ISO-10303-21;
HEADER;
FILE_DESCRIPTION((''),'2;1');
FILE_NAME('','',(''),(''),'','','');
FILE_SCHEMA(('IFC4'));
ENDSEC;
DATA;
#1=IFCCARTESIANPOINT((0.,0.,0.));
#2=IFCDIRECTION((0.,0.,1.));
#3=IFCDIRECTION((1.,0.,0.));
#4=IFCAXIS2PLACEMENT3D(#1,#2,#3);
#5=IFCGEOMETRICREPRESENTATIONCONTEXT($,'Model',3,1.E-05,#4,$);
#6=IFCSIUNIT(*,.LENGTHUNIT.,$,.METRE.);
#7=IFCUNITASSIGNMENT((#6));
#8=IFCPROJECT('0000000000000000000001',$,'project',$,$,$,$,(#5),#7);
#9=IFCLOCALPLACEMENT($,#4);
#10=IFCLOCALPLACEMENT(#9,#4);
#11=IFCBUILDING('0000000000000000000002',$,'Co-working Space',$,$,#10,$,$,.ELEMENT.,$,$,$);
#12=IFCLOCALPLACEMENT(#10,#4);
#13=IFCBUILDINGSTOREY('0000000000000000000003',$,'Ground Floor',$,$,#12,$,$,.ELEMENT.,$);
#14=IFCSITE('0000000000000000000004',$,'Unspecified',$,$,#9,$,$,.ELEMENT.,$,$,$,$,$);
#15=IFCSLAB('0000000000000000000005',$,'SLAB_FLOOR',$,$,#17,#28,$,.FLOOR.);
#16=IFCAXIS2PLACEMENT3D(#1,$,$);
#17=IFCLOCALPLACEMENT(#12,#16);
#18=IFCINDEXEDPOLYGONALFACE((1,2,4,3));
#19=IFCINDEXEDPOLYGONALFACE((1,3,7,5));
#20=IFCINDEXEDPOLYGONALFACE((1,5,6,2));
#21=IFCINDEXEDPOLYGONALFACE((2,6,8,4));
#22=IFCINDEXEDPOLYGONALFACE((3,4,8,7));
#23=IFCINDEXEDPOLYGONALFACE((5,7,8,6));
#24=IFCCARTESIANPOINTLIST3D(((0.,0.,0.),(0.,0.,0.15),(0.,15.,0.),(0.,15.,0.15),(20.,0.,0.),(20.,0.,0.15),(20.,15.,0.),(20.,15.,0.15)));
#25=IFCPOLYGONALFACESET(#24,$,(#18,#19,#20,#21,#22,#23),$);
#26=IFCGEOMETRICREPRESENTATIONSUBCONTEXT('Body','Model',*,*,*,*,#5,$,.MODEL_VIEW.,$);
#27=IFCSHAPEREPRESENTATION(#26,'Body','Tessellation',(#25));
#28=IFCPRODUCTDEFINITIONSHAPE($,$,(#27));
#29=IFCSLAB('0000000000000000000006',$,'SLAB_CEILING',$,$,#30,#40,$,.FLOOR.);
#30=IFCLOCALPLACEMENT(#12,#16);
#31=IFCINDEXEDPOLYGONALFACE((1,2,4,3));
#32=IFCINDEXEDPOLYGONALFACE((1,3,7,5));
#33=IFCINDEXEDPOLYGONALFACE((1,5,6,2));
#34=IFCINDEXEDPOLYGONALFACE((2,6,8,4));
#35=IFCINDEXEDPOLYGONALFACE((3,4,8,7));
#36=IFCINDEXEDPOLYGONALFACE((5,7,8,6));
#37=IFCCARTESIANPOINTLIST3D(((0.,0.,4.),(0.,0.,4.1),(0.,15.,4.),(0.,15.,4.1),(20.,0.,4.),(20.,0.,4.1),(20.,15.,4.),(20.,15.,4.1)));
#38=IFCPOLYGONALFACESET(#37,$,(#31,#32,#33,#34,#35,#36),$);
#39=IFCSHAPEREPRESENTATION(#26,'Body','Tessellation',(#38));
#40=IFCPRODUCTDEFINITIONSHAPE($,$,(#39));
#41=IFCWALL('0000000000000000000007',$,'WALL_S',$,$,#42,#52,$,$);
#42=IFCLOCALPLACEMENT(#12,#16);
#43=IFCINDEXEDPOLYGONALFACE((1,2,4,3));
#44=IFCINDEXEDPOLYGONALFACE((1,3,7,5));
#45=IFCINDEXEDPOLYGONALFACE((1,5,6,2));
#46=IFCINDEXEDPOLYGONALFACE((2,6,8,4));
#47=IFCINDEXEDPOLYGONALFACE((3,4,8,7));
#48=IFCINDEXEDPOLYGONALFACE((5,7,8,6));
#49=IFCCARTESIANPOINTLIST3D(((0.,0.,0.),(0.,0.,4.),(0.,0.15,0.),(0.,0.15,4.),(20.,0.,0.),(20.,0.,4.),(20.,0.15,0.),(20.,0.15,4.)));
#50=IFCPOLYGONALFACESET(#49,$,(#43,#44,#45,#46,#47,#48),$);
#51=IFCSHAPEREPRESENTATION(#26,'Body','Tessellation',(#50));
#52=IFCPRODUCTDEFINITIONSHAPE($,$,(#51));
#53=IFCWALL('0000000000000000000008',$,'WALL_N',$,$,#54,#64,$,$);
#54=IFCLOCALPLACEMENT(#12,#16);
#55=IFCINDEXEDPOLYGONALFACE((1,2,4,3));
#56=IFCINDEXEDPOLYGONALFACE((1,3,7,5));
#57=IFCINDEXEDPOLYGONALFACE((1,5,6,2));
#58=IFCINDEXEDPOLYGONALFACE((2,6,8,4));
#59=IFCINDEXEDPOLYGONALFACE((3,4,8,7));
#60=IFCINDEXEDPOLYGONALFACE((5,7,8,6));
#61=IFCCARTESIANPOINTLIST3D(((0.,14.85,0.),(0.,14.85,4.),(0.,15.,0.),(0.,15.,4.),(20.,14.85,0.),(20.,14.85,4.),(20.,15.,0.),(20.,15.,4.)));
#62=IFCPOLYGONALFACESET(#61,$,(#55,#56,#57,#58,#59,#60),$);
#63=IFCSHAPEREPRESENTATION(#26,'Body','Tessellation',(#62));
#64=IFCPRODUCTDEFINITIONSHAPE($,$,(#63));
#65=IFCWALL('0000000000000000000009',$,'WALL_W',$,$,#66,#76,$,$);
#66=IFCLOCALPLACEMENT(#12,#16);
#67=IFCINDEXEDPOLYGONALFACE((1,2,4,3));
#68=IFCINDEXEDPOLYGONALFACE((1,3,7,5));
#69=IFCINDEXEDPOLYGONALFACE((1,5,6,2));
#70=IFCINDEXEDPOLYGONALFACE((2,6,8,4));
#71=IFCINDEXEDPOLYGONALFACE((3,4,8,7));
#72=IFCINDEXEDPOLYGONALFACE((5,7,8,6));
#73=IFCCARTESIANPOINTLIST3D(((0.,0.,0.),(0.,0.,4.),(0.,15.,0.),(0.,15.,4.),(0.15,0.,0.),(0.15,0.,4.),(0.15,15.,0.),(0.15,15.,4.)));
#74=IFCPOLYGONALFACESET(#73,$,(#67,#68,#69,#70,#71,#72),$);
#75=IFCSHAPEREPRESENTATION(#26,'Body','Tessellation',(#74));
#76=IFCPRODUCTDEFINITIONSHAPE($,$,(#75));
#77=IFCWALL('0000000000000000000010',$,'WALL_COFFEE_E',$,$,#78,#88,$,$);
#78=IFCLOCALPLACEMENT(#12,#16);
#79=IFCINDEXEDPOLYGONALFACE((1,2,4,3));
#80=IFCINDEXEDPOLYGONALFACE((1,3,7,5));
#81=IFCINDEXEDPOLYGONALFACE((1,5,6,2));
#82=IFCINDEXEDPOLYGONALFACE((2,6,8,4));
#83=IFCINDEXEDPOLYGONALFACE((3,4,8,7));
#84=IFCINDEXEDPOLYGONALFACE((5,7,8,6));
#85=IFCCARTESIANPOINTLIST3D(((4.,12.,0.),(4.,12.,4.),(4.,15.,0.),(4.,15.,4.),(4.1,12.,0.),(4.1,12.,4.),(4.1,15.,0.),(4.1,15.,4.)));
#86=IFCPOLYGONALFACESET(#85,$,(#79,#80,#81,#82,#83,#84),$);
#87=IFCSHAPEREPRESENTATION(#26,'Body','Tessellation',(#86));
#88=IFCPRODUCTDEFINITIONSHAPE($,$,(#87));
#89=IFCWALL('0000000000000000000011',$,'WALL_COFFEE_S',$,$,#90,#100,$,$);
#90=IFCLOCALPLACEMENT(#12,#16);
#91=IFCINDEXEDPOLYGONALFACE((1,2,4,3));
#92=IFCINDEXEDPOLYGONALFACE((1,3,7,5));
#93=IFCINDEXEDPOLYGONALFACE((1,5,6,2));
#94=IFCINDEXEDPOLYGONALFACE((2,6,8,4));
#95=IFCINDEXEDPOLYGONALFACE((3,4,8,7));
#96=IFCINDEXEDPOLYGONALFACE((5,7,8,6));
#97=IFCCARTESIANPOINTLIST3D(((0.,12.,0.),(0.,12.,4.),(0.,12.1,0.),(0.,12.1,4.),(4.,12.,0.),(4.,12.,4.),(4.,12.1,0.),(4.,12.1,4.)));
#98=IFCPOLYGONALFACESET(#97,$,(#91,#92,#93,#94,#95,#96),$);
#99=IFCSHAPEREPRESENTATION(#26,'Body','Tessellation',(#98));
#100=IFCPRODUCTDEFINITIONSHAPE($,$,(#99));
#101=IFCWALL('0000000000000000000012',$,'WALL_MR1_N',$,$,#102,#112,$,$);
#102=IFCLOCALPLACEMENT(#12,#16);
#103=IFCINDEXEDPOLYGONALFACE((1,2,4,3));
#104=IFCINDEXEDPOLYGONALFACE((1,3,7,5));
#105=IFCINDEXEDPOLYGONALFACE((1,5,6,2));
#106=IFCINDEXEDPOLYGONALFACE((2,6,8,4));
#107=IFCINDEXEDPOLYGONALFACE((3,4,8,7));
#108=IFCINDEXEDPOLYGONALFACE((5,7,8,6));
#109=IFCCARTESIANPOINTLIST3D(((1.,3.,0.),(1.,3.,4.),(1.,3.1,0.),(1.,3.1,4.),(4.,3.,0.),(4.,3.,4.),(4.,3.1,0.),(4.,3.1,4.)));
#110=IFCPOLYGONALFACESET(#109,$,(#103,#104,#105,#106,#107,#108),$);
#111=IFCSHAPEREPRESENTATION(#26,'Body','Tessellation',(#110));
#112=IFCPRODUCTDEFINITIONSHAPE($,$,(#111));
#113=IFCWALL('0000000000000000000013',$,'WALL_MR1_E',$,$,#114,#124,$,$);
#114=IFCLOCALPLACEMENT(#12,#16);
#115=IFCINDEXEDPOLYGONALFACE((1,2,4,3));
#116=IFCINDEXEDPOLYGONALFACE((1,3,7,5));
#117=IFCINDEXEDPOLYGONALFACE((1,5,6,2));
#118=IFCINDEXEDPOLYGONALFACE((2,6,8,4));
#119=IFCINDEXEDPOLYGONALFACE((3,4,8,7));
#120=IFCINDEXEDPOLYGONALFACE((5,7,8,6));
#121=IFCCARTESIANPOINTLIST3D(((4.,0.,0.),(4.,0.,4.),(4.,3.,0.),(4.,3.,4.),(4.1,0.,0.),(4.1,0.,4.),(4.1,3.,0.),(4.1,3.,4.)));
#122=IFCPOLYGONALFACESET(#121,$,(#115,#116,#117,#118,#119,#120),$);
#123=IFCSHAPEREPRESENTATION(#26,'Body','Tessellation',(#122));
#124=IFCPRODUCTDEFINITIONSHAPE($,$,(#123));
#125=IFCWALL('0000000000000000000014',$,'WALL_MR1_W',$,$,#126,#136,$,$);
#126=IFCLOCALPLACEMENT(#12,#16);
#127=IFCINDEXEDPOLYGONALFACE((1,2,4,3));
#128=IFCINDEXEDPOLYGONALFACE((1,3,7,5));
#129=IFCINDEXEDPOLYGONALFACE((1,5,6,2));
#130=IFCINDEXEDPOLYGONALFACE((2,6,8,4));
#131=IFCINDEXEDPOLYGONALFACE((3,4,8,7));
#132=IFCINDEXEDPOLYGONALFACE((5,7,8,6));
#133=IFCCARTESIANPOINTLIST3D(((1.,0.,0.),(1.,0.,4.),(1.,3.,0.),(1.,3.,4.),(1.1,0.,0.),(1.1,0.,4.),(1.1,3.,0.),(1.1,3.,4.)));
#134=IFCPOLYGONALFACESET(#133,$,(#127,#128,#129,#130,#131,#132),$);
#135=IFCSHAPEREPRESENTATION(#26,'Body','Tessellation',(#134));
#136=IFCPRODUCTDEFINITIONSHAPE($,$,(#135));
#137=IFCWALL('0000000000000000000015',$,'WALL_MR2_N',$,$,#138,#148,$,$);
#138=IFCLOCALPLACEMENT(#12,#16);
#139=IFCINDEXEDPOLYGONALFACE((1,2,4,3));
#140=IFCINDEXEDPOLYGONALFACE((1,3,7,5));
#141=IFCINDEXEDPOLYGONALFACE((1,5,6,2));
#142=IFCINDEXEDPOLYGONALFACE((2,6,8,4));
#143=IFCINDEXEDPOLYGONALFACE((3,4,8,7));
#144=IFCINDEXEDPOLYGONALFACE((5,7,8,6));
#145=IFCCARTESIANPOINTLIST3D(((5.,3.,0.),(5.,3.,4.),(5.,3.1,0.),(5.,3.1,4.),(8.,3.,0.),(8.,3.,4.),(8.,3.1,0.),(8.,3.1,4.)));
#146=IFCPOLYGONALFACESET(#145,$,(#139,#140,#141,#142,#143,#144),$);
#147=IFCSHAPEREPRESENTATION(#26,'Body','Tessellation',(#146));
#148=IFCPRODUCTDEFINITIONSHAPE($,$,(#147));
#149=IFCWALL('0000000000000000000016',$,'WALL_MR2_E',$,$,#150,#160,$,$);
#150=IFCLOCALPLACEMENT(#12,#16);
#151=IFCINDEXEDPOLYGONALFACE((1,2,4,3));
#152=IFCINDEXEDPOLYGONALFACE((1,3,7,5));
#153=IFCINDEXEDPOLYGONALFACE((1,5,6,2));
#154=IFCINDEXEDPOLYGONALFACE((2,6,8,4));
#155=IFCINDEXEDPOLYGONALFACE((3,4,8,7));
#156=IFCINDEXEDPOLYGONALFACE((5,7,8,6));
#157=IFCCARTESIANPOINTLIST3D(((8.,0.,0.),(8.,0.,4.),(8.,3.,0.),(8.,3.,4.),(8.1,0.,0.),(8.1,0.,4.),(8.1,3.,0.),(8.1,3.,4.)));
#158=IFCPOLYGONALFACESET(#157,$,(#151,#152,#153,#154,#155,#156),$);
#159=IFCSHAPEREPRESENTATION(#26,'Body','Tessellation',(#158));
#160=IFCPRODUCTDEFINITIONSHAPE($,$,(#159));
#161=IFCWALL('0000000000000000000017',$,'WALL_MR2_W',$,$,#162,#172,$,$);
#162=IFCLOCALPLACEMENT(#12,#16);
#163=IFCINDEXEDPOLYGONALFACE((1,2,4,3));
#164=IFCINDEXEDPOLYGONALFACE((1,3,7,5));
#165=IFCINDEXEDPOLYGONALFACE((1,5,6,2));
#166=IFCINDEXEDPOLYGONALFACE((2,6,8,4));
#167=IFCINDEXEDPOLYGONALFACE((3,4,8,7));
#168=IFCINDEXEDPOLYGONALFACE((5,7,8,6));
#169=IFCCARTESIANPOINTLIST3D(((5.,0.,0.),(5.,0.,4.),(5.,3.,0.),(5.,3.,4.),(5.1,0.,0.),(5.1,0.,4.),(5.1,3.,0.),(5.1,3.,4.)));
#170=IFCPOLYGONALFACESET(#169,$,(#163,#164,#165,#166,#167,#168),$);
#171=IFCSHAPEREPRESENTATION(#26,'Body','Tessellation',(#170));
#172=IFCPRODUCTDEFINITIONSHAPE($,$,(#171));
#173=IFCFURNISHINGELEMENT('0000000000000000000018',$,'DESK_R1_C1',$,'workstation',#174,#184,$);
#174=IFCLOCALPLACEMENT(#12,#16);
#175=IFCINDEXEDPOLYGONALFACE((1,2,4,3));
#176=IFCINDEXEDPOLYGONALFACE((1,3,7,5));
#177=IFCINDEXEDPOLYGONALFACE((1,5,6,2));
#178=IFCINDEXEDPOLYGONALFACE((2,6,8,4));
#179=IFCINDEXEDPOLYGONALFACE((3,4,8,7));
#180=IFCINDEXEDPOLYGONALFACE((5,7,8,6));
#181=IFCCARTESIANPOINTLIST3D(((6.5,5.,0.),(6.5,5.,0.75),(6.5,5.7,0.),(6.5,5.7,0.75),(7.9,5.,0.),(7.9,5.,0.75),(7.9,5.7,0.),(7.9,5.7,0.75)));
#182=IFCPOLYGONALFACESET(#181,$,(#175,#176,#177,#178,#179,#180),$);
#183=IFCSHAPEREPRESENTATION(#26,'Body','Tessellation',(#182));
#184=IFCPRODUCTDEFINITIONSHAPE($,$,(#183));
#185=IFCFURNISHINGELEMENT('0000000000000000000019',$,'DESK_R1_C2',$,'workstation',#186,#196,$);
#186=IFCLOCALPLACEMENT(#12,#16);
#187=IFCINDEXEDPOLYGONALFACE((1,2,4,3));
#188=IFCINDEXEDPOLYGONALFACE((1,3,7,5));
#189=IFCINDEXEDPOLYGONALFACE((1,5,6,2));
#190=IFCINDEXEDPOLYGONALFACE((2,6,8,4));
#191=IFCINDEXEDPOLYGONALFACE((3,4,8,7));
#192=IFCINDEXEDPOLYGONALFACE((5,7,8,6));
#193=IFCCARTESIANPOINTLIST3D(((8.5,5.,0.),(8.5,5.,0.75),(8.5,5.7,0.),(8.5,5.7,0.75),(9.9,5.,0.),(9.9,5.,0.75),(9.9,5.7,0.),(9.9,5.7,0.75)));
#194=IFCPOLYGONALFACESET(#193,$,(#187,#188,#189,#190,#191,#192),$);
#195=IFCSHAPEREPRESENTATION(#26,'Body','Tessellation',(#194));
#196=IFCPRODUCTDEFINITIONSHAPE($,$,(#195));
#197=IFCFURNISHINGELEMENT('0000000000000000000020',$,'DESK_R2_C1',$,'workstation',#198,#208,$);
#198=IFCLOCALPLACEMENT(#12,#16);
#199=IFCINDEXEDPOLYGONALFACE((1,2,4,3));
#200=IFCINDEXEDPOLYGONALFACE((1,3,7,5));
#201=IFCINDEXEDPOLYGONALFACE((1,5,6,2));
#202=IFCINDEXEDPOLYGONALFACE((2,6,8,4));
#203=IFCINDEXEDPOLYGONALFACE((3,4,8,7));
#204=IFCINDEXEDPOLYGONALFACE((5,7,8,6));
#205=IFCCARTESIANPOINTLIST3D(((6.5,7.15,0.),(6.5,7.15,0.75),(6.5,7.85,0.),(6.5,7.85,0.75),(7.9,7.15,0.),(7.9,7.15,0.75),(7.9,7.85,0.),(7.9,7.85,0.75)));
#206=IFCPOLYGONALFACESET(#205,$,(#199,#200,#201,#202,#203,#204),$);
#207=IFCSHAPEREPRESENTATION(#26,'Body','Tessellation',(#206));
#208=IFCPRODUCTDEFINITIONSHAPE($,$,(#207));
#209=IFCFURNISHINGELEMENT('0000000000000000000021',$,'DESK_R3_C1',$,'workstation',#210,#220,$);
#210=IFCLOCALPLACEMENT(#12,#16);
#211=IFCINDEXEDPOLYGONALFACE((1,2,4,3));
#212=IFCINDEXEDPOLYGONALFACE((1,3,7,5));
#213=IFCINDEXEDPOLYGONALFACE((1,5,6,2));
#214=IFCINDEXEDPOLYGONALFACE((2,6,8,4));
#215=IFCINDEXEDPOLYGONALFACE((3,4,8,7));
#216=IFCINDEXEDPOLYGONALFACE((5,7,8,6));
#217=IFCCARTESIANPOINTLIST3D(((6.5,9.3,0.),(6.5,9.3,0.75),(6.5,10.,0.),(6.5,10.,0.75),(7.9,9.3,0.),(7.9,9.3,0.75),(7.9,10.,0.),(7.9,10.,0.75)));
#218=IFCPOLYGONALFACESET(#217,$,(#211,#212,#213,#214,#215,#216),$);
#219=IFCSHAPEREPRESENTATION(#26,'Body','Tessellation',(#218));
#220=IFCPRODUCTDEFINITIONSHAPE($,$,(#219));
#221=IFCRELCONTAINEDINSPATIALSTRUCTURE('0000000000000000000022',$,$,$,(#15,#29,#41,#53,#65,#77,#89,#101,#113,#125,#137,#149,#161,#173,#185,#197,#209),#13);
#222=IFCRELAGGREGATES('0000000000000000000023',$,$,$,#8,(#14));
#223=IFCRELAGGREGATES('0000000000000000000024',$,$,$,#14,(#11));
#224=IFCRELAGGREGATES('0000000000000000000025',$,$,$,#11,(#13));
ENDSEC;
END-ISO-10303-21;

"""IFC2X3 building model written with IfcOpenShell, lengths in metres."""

from ifc_helpers import new_model, si_unit, frame, frame_2d, origin, origin_with_axes, place, context, subcontext, project, spatial, rectangle, extrude, element, save


model = new_model("IFC2X3")

# Units and contexts
model_context = context("Model", 3, precision=1e-05, world=origin_with_axes())
body_context = subcontext(model_context, "Body", "Model", "MODEL_VIEW")
ifc_project = project(units=[si_unit("LENGTHUNIT", "METRE")], contexts=[model_context])

# Site, building, storey
site_placement = place(None, origin_with_axes())
site = spatial("IfcSite", under=ifc_project, at=site_placement, Name="Unspecified", CompositionType="ELEMENT")
building_placement = place(site_placement, origin_with_axes())
building = spatial("IfcBuilding", under=site, at=building_placement, Name="Co-working Space", CompositionType="ELEMENT")
storey_placement = place(building_placement, origin_with_axes())
storey = spatial("IfcBuildingStorey", under=building, at=storey_placement, Name="Ground Floor", CompositionType="ELEMENT")

# Slabs
slab_1_placement = place(storey_placement, origin_with_axes())
element("IfcSlab", 1, at=slab_1_placement, inside=storey, Name="SLAB_FLOOR", PredefinedType="FLOOR", context=body_context, shape_type="SweptSolid", body=[
    extrude(rectangle(XDim=20.0, YDim=15.0, at=frame_2d((10.0, 7.5))), origin(), (0.0, 0.0, 1.0), 0.15),
])
slab_2_placement = place(storey_placement, frame((0.0, 0.0, 4.0), z_axis=(0.0, 0.0, 1.0), x_axis=(1.0, 0.0, 0.0)))
element("IfcSlab", 2, at=slab_2_placement, inside=storey, Name="SLAB_CEILING", PredefinedType="FLOOR", context=body_context, shape_type="SweptSolid", body=[
    extrude(rectangle(XDim=20.0, YDim=15.0, at=frame_2d((10.0, 7.5))), origin(), (0.0, 0.0, 1.0), 0.1),
])

# Walls
for number, where, z_axis, x_axis, name in (
    (3, (0.0, 0.0, 0.0), (0.0, 0.0, 1.0), (1.0, 0.0, 0.0), "WALL_S"),
    (4, (0.0, 14.85, 0.0), (0.0, 0.0, 1.0), (1.0, 0.0, 0.0), "WALL_N"),
):
    element("IfcWall", number, at=place(storey_placement, frame(where, z_axis=z_axis, x_axis=x_axis)), inside=storey, Name=name, context=body_context, shape_type="SweptSolid", body=[
        extrude(rectangle(XDim=20.0, YDim=0.15, at=frame_2d((10.0, 0.075))), origin(), (0.0, 0.0, 1.0), 4.0),
    ])
wall_1_placement = place(storey_placement, origin_with_axes())
element("IfcWall", 5, at=wall_1_placement, inside=storey, Name="WALL_W", context=body_context, shape_type="SweptSolid", body=[
    extrude(rectangle(XDim=0.15, YDim=15.0, at=frame_2d((0.075, 7.5))), origin(), (0.0, 0.0, 1.0), 4.0),
])
wall_2_placement = place(storey_placement, frame((4.0, 12.0, 0.0), z_axis=(0.0, 0.0, 1.0), x_axis=(1.0, 0.0, 0.0)))
element("IfcWall", 6, at=wall_2_placement, inside=storey, Name="WALL_COFFEE_E", context=body_context, shape_type="SweptSolid", body=[
    extrude(rectangle(XDim=0.1, YDim=3.0, at=frame_2d((0.05, 1.5))), origin(), (0.0, 0.0, 1.0), 4.0),
])
wall_3_placement = place(storey_placement, frame((0.0, 12.0, 0.0), z_axis=(0.0, 0.0, 1.0), x_axis=(1.0, 0.0, 0.0)))
element("IfcWall", 7, at=wall_3_placement, inside=storey, Name="WALL_COFFEE_S", context=body_context, shape_type="SweptSolid", body=[
    extrude(rectangle(XDim=4.0, YDim=0.1, at=frame_2d((2.0, 0.05))), origin(), (0.0, 0.0, 1.0), 4.0),
])
wall_4_placement = place(storey_placement, frame((1.0, 3.0, 0.0), z_axis=(0.0, 0.0, 1.0), x_axis=(1.0, 0.0, 0.0)))
element("IfcWall", 8, at=wall_4_placement, inside=storey, Name="WALL_MR1_N", context=body_context, shape_type="SweptSolid", body=[
    extrude(rectangle(XDim=3.0, YDim=0.1, at=frame_2d((1.5, 0.05))), origin(), (0.0, 0.0, 1.0), 4.0),
])
for number, where, z_axis, x_axis, name in (
    (9, (4.0, 0.0, 0.0), (0.0, 0.0, 1.0), (1.0, 0.0, 0.0), "WALL_MR1_E"),
    (10, (1.0, 0.0, 0.0), (0.0, 0.0, 1.0), (1.0, 0.0, 0.0), "WALL_MR1_W"),
):
    element("IfcWall", number, at=place(storey_placement, frame(where, z_axis=z_axis, x_axis=x_axis)), inside=storey, Name=name, context=body_context, shape_type="SweptSolid", body=[
        extrude(rectangle(XDim=0.1, YDim=3.0, at=frame_2d((0.05, 1.5))), origin(), (0.0, 0.0, 1.0), 4.0),
    ])
wall_5_placement = place(storey_placement, frame((5.0, 3.0, 0.0), z_axis=(0.0, 0.0, 1.0), x_axis=(1.0, 0.0, 0.0)))
element("IfcWall", 11, at=wall_5_placement, inside=storey, Name="WALL_MR2_N", context=body_context, shape_type="SweptSolid", body=[
    extrude(rectangle(XDim=3.0, YDim=0.1, at=frame_2d((1.5, 0.05))), origin(), (0.0, 0.0, 1.0), 4.0),
])
for number, where, z_axis, x_axis, name in (
    (12, (8.0, 0.0, 0.0), (0.0, 0.0, 1.0), (1.0, 0.0, 0.0), "WALL_MR2_E"),
    (13, (5.0, 0.0, 0.0), (0.0, 0.0, 1.0), (1.0, 0.0, 0.0), "WALL_MR2_W"),
):
    element("IfcWall", number, at=place(storey_placement, frame(where, z_axis=z_axis, x_axis=x_axis)), inside=storey, Name=name, context=body_context, shape_type="SweptSolid", body=[
        extrude(rectangle(XDim=0.1, YDim=3.0, at=frame_2d((0.05, 1.5))), origin(), (0.0, 0.0, 1.0), 4.0),
    ])

# Furnishing elements
for number, where, z_axis, x_axis, name in (
    (14, (6.5, 5.0, 0.0), (0.0, 0.0, 1.0), (1.0, 0.0, 0.0), "DESK_R1_C1"),
    (15, (8.5, 5.0, 0.0), (0.0, 0.0, 1.0), (1.0, 0.0, 0.0), "DESK_R1_C2"),
    (16, (6.5, 7.15, 0.0), (0.0, 0.0, 1.0), (1.0, 0.0, 0.0), "DESK_R2_C1"),
    (17, (6.5, 9.3, 0.0), (0.0, 0.0, 1.0), (1.0, 0.0, 0.0), "DESK_R3_C1"),
):
    element("IfcFurnishingElement", number, at=place(storey_placement, frame(where, z_axis=z_axis, x_axis=x_axis)), inside=storey, Name=name, ObjectType="workstation", context=body_context, shape_type="SweptSolid", body=[
        extrude(rectangle(XDim=1.4, YDim=0.7, at=frame_2d((0.7, 0.35))), origin(), (0.0, 0.0, 1.0), 0.75),
    ])

save(model, "model.ifc")
